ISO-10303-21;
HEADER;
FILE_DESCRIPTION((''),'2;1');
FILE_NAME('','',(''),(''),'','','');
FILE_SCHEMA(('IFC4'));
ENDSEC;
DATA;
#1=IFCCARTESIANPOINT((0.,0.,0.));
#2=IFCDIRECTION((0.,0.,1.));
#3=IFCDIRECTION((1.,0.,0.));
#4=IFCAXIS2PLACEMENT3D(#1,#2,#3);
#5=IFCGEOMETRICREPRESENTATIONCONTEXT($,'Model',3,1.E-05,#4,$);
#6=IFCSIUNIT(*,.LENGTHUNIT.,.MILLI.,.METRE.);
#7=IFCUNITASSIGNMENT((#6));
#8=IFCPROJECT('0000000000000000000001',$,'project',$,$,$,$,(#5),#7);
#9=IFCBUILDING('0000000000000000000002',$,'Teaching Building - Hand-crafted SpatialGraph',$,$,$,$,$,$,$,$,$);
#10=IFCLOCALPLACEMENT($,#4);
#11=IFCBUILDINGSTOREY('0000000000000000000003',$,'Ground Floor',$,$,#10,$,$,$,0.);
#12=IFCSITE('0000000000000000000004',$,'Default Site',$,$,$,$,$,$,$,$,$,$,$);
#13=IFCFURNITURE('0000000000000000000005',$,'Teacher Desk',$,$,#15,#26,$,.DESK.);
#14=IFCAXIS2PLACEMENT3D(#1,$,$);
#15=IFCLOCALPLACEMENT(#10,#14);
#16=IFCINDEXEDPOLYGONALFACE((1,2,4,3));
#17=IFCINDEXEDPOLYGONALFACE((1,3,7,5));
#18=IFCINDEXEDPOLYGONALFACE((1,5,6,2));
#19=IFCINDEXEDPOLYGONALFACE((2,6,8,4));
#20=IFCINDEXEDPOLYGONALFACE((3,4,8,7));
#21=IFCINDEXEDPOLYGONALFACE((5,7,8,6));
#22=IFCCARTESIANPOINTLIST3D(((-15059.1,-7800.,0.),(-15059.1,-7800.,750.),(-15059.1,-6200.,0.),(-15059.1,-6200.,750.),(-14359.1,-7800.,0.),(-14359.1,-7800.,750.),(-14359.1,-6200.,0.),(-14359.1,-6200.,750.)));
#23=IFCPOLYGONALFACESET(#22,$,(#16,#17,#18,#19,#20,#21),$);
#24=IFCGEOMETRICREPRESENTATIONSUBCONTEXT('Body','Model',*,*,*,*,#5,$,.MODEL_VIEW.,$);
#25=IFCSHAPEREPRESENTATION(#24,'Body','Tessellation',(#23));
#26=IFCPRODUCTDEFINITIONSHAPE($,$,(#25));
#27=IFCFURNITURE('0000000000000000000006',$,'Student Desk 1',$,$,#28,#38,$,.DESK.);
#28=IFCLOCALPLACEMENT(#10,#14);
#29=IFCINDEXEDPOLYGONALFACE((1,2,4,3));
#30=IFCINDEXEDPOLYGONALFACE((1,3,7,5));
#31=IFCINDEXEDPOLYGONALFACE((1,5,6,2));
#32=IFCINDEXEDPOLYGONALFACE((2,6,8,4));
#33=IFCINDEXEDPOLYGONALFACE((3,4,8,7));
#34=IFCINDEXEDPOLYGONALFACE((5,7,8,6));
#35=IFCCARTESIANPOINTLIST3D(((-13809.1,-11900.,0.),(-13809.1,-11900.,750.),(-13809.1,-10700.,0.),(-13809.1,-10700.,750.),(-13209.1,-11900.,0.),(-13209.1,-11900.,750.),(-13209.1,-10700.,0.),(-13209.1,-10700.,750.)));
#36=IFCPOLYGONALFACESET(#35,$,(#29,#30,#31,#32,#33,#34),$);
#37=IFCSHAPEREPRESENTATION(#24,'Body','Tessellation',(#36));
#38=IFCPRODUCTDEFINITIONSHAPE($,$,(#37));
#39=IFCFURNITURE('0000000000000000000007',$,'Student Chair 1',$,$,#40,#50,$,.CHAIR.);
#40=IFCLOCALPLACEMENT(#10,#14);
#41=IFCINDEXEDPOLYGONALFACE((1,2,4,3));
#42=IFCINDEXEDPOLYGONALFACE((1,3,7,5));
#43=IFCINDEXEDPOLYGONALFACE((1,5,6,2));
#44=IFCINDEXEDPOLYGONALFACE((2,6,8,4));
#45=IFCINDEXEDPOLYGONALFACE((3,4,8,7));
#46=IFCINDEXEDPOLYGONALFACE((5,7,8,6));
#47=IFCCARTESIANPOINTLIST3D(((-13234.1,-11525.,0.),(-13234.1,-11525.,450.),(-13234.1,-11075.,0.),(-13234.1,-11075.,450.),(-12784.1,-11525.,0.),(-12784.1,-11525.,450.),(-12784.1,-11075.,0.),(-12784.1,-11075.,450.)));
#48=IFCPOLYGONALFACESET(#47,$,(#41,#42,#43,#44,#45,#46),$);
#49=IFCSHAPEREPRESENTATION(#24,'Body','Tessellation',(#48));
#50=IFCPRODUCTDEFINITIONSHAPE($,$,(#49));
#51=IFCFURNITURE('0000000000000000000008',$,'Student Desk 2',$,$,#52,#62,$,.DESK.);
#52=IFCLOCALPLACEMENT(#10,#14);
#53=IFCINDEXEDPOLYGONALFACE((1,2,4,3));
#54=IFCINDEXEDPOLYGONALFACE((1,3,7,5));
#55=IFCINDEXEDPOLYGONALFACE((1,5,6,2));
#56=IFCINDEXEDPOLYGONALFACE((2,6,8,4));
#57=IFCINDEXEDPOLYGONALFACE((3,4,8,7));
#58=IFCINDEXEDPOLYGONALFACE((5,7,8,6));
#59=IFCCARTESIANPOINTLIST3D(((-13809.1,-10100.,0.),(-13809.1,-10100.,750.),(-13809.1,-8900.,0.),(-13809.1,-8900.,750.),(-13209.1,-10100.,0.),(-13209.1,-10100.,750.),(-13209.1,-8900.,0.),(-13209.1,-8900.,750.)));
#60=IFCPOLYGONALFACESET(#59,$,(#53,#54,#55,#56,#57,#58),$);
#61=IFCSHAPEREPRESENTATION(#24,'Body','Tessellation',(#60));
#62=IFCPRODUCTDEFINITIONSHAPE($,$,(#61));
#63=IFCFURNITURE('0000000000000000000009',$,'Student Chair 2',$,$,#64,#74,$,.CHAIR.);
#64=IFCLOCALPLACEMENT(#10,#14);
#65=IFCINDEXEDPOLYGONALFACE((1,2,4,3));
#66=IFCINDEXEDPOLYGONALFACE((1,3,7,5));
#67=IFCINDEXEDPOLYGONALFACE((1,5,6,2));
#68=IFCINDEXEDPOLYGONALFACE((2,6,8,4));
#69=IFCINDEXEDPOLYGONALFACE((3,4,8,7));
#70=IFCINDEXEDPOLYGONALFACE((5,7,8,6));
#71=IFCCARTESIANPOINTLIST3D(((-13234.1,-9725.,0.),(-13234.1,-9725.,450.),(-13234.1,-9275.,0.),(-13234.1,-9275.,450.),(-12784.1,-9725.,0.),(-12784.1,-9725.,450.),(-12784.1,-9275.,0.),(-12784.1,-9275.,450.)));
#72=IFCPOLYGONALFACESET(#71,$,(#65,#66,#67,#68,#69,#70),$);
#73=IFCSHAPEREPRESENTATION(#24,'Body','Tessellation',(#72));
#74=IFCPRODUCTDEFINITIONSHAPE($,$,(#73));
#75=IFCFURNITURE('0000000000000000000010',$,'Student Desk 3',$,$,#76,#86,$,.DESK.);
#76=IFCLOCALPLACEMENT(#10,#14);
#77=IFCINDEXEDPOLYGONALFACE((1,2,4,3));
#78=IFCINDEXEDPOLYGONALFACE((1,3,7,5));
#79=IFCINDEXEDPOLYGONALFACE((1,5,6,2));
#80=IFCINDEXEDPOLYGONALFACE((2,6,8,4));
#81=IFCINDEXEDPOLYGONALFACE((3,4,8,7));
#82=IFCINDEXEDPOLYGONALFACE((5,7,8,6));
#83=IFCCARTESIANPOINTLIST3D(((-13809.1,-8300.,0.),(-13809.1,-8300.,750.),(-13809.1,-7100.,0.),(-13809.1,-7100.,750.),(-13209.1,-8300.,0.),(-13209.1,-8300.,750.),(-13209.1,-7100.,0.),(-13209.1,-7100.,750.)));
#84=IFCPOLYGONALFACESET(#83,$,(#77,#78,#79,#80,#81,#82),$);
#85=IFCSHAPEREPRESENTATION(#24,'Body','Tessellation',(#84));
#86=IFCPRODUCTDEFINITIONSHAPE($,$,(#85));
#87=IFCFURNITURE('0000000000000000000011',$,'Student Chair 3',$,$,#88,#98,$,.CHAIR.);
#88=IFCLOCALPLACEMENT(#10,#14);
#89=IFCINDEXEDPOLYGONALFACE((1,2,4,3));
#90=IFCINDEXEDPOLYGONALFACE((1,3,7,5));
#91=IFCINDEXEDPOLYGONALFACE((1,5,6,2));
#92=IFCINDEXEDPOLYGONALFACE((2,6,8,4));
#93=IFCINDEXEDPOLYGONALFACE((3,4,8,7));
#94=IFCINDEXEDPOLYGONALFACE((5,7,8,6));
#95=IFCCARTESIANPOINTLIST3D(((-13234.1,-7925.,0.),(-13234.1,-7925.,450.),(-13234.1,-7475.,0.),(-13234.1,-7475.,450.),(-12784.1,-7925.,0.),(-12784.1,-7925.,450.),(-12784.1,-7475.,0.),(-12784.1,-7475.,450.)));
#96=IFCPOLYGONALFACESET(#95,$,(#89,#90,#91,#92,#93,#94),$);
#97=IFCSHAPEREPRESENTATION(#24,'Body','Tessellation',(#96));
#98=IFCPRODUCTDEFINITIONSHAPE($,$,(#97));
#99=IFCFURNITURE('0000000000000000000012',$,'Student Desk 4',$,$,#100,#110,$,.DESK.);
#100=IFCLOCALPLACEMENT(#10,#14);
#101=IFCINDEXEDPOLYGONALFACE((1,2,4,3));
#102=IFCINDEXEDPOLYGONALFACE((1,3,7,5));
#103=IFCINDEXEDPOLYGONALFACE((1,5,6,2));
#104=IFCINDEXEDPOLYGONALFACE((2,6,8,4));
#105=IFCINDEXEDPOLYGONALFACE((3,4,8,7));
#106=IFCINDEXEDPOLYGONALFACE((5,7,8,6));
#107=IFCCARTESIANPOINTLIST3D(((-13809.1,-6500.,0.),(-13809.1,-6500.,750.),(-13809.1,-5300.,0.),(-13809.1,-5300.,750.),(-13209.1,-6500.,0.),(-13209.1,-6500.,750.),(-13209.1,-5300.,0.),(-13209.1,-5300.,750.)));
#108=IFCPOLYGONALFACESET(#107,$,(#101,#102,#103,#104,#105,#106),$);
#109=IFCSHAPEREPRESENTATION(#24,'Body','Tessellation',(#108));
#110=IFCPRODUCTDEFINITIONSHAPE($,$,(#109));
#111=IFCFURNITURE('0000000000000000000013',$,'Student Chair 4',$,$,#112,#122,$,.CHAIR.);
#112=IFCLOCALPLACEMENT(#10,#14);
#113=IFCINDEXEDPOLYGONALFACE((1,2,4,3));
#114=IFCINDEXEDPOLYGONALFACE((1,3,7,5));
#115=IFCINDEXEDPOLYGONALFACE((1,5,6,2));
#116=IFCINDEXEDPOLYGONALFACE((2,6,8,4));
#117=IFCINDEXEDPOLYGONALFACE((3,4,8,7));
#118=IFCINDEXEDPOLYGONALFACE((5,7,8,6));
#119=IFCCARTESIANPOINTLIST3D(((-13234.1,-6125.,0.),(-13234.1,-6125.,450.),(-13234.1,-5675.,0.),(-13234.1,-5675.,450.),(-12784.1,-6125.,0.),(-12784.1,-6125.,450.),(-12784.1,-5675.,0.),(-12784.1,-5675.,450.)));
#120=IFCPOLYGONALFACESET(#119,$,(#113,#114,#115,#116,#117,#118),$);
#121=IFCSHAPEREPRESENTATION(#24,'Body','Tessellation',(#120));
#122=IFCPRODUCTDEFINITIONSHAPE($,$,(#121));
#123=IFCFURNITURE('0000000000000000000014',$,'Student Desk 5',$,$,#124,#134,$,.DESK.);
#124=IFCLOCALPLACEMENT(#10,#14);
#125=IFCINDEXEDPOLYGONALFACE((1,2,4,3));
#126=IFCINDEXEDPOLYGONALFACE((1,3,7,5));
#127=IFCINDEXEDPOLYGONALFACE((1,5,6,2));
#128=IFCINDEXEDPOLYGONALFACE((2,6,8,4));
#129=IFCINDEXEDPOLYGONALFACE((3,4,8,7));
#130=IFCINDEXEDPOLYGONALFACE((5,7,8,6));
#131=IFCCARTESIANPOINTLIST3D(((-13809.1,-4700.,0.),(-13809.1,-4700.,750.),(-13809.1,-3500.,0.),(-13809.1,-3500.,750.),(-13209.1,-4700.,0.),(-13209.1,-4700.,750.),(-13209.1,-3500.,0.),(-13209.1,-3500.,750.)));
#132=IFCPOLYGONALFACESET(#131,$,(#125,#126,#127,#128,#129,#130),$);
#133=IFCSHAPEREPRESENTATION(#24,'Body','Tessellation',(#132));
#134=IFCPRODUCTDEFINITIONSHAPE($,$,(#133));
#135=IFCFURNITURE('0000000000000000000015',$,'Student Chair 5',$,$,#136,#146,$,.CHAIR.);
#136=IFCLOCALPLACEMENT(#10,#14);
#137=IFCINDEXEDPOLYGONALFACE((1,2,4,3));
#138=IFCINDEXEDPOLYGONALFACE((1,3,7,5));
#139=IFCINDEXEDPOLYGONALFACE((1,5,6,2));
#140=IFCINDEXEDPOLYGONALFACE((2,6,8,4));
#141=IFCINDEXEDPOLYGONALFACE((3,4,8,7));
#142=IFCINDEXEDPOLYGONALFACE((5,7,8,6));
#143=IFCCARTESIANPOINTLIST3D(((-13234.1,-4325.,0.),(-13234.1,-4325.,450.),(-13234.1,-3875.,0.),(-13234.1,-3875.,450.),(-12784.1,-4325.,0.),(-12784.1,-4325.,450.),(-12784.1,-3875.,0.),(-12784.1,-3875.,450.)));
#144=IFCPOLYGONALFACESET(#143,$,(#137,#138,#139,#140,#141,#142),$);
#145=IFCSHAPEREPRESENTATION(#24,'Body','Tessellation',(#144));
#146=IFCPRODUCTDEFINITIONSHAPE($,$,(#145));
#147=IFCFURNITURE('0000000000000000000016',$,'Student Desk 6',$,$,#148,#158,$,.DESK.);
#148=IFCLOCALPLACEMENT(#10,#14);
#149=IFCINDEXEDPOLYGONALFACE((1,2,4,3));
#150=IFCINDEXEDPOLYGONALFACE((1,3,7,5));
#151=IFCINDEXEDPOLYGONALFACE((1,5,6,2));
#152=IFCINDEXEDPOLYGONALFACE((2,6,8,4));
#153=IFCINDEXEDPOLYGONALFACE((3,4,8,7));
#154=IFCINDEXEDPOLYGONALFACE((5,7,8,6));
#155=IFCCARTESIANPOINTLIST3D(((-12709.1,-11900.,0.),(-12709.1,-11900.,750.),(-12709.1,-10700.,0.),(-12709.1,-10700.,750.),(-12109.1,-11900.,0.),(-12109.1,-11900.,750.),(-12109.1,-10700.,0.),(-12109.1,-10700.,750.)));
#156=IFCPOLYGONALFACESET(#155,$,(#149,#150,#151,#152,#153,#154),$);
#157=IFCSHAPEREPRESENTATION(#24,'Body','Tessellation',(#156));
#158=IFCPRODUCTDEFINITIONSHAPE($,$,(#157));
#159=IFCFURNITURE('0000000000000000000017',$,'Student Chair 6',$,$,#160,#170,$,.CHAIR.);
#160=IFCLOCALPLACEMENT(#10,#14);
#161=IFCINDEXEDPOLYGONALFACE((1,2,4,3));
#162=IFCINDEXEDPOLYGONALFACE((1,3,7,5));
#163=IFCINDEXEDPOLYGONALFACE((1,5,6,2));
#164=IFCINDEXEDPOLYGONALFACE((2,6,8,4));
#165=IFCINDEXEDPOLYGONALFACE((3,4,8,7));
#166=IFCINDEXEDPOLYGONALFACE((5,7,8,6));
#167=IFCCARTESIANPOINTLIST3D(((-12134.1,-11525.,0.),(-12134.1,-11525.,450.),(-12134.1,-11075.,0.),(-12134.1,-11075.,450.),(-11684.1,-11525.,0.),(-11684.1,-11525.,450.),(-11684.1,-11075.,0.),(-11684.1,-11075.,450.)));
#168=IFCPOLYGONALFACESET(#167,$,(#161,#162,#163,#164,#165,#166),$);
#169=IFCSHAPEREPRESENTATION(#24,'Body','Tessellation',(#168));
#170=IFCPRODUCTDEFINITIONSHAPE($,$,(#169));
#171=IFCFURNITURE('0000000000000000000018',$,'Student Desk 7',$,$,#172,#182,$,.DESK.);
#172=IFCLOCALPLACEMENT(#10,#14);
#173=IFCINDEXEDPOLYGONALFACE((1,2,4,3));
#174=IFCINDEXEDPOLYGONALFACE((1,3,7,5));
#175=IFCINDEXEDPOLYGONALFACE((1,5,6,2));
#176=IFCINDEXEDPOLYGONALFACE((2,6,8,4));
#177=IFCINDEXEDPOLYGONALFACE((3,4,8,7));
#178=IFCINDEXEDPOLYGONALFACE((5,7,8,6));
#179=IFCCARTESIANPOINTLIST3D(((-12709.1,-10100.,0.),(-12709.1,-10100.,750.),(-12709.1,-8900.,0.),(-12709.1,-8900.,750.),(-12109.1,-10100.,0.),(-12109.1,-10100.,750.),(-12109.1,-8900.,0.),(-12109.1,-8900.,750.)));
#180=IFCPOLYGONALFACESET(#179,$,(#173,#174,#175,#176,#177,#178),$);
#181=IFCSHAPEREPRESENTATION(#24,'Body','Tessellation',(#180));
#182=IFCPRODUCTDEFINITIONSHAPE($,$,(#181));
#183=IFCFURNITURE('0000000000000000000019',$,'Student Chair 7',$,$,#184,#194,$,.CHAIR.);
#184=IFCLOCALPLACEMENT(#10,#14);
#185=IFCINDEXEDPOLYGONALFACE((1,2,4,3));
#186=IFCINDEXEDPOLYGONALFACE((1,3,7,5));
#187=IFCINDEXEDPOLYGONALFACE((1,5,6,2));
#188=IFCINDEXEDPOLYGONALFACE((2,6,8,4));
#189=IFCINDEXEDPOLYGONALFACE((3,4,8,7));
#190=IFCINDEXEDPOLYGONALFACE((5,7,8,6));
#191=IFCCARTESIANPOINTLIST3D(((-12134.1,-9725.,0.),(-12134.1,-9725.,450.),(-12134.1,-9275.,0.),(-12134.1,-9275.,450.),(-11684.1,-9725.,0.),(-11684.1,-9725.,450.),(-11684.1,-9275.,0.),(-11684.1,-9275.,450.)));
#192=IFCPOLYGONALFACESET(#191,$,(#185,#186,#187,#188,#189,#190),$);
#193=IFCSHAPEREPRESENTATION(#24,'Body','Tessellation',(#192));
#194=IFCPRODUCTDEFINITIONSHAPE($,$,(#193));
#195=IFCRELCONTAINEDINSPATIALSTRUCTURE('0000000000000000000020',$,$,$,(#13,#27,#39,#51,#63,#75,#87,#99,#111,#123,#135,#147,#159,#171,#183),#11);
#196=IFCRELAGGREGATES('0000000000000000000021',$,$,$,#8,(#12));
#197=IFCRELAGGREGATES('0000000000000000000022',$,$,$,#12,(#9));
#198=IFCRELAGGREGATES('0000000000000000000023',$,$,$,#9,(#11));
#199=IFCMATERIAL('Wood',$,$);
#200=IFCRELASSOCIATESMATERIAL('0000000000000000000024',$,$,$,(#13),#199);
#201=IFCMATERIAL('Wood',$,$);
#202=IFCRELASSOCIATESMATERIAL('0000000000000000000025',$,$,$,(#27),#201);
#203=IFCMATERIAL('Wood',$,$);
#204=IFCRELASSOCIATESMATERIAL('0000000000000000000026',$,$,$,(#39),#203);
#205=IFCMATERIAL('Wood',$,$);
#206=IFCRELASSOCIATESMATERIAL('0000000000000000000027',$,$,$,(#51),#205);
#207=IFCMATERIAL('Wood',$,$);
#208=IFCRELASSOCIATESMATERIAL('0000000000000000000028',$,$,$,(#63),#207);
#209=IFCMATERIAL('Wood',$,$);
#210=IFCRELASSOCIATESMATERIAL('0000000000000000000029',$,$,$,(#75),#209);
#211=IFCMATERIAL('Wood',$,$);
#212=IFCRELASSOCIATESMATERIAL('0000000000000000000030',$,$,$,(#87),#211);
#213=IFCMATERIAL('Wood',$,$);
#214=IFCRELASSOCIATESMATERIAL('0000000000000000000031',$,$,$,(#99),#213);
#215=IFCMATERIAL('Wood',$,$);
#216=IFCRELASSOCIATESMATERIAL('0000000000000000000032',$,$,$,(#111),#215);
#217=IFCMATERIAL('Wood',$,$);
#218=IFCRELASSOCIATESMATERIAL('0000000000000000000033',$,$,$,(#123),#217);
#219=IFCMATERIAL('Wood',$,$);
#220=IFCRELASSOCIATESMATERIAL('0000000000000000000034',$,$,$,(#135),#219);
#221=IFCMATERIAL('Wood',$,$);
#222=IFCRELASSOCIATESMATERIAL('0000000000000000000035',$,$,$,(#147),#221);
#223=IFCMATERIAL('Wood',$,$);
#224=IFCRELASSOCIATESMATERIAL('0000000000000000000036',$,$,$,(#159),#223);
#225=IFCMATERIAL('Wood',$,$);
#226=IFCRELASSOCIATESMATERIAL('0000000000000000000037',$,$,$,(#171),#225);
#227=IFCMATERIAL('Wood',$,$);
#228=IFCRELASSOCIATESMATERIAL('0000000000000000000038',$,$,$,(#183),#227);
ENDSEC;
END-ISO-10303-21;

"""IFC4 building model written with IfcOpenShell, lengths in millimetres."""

from ifc_helpers import new_model, si_unit, frame, origin_with_axes, origin_2d, place, context, subcontext, project, spatial, rectangle, extrude, material, element, save


model = new_model("IFC4")

# Units and contexts
model_context = context("Model", 3, precision=1e-05, world=origin_with_axes())
body_context = subcontext(model_context, "Body", "Model", "MODEL_VIEW")
ifc_project = project(units=[si_unit("LENGTHUNIT", "METRE", prefix="MILLI")], contexts=[model_context])

# Site, building, storey
site = spatial("IfcSite", under=ifc_project, Name="Default Site")
building = spatial("IfcBuilding", under=site, Name="Teaching Building - Hand-crafted SpatialGraph")
storey_placement = place(None, origin_with_axes())
storey = spatial("IfcBuildingStorey", under=building, at=storey_placement, Name="Ground Floor", Elevation=0.0)

# Furniture
ifc_material_1 = material(Name="Wood")
furniture_1_placement = place(storey_placement, frame((-14709.1, -7000.0, 0.0), z_axis=(0.0, 0.0, 1.0), x_axis=(0.0, 1.0, 0.0)))
element("IfcFurniture", 1, at=furniture_1_placement, inside=storey, material=ifc_material_1, Name="Teacher Desk", PredefinedType="DESK", context=body_context, shape_type="SweptSolid", body=[
    extrude(rectangle(XDim=1600.0, YDim=700.0, at=origin_2d()), origin_with_axes(), (0.0, 0.0, 1.0), 750.0),
])
ifc_material_2 = material(Name="Wood")
furniture_2_placement = place(storey_placement, frame((-13509.1, -11300.0, 0.0), z_axis=(0.0, 0.0, 1.0), x_axis=(0.0, 1.0, 0.0)))
element("IfcFurniture", 2, at=furniture_2_placement, inside=storey, material=ifc_material_2, Name="Student Desk 1", PredefinedType="DESK", context=body_context, shape_type="SweptSolid", body=[
    extrude(rectangle(XDim=1200.0, YDim=600.0, at=origin_2d()), origin_with_axes(), (0.0, 0.0, 1.0), 750.0),
])
ifc_material_3 = material(Name="Wood")
furniture_3_placement = place(storey_placement, frame((-13009.1, -11300.0, 0.0), z_axis=(0.0, 0.0, 1.0), x_axis=(1.0, 0.0, 0.0)))
element("IfcFurniture", 3, at=furniture_3_placement, inside=storey, material=ifc_material_3, Name="Student Chair 1", PredefinedType="CHAIR", context=body_context, shape_type="SweptSolid", body=[
    extrude(rectangle(XDim=450.0, YDim=450.0, at=origin_2d()), origin_with_axes(), (0.0, 0.0, 1.0), 450.0),
])
ifc_material_4 = material(Name="Wood")
furniture_4_placement = place(storey_placement, frame((-13509.1, -9500.0, 0.0), z_axis=(0.0, 0.0, 1.0), x_axis=(0.0, 1.0, 0.0)))
element("IfcFurniture", 4, at=furniture_4_placement, inside=storey, material=ifc_material_4, Name="Student Desk 2", PredefinedType="DESK", context=body_context, shape_type="SweptSolid", body=[
    extrude(rectangle(XDim=1200.0, YDim=600.0, at=origin_2d()), origin_with_axes(), (0.0, 0.0, 1.0), 750.0),
])
ifc_material_5 = material(Name="Wood")
furniture_5_placement = place(storey_placement, frame((-13009.1, -9500.0, 0.0), z_axis=(0.0, 0.0, 1.0), x_axis=(1.0, 0.0, 0.0)))
element("IfcFurniture", 5, at=furniture_5_placement, inside=storey, material=ifc_material_5, Name="Student Chair 2", PredefinedType="CHAIR", context=body_context, shape_type="SweptSolid", body=[
    extrude(rectangle(XDim=450.0, YDim=450.0, at=origin_2d()), origin_with_axes(), (0.0, 0.0, 1.0), 450.0),
])
ifc_material_6 = material(Name="Wood")
furniture_6_placement = place(storey_placement, frame((-13509.1, -7700.0, 0.0), z_axis=(0.0, 0.0, 1.0), x_axis=(0.0, 1.0, 0.0)))
element("IfcFurniture", 6, at=furniture_6_placement, inside=storey, material=ifc_material_6, Name="Student Desk 3", PredefinedType="DESK", context=body_context, shape_type="SweptSolid", body=[
    extrude(rectangle(XDim=1200.0, YDim=600.0, at=origin_2d()), origin_with_axes(), (0.0, 0.0, 1.0), 750.0),
])
ifc_material_7 = material(Name="Wood")
furniture_7_placement = place(storey_placement, frame((-13009.1, -7700.0, 0.0), z_axis=(0.0, 0.0, 1.0), x_axis=(1.0, 0.0, 0.0)))
element("IfcFurniture", 7, at=furniture_7_placement, inside=storey, material=ifc_material_7, Name="Student Chair 3", PredefinedType="CHAIR", context=body_context, shape_type="SweptSolid", body=[
    extrude(rectangle(XDim=450.0, YDim=450.0, at=origin_2d()), origin_with_axes(), (0.0, 0.0, 1.0), 450.0),
])
ifc_material_8 = material(Name="Wood")
furniture_8_placement = place(storey_placement, frame((-13509.1, -5900.0, 0.0), z_axis=(0.0, 0.0, 1.0), x_axis=(0.0, 1.0, 0.0)))
element("IfcFurniture", 8, at=furniture_8_placement, inside=storey, material=ifc_material_8, Name="Student Desk 4", PredefinedType="DESK", context=body_context, shape_type="SweptSolid", body=[
    extrude(rectangle(XDim=1200.0, YDim=600.0, at=origin_2d()), origin_with_axes(), (0.0, 0.0, 1.0), 750.0),
])
ifc_material_9 = material(Name="Wood")
furniture_9_placement = place(storey_placement, frame((-13009.1, -5900.0, 0.0), z_axis=(0.0, 0.0, 1.0), x_axis=(1.0, 0.0, 0.0)))
element("IfcFurniture", 9, at=furniture_9_placement, inside=storey, material=ifc_material_9, Name="Student Chair 4", PredefinedType="CHAIR", context=body_context, shape_type="SweptSolid", body=[
    extrude(rectangle(XDim=450.0, YDim=450.0, at=origin_2d()), origin_with_axes(), (0.0, 0.0, 1.0), 450.0),
])
ifc_material_10 = material(Name="Wood")
furniture_10_placement = place(storey_placement, frame((-13509.1, -4100.0, 0.0), z_axis=(0.0, 0.0, 1.0), x_axis=(0.0, 1.0, 0.0)))
element("IfcFurniture", 10, at=furniture_10_placement, inside=storey, material=ifc_material_10, Name="Student Desk 5", PredefinedType="DESK", context=body_context, shape_type="SweptSolid", body=[
    extrude(rectangle(XDim=1200.0, YDim=600.0, at=origin_2d()), origin_with_axes(), (0.0, 0.0, 1.0), 750.0),
])
ifc_material_11 = material(Name="Wood")
furniture_11_placement = place(storey_placement, frame((-13009.1, -4100.0, 0.0), z_axis=(0.0, 0.0, 1.0), x_axis=(1.0, 0.0, 0.0)))
element("IfcFurniture", 11, at=furniture_11_placement, inside=storey, material=ifc_material_11, Name="Student Chair 5", PredefinedType="CHAIR", context=body_context, shape_type="SweptSolid", body=[
    extrude(rectangle(XDim=450.0, YDim=450.0, at=origin_2d()), origin_with_axes(), (0.0, 0.0, 1.0), 450.0),
])
ifc_material_12 = material(Name="Wood")
furniture_12_placement = place(storey_placement, frame((-12409.1, -11300.0, 0.0), z_axis=(0.0, 0.0, 1.0), x_axis=(0.0, 1.0, 0.0)))
element("IfcFurniture", 12, at=furniture_12_placement, inside=storey, material=ifc_material_12, Name="Student Desk 6", PredefinedType="DESK", context=body_context, shape_type="SweptSolid", body=[
    extrude(rectangle(XDim=1200.0, YDim=600.0, at=origin_2d()), origin_with_axes(), (0.0, 0.0, 1.0), 750.0),
])
ifc_material_13 = material(Name="Wood")
furniture_13_placement = place(storey_placement, frame((-11909.1, -11300.0, 0.0), z_axis=(0.0, 0.0, 1.0), x_axis=(1.0, 0.0, 0.0)))
element("IfcFurniture", 13, at=furniture_13_placement, inside=storey, material=ifc_material_13, Name="Student Chair 6", PredefinedType="CHAIR", context=body_context, shape_type="SweptSolid", body=[
    extrude(rectangle(XDim=450.0, YDim=450.0, at=origin_2d()), origin_with_axes(), (0.0, 0.0, 1.0), 450.0),
])
ifc_material_14 = material(Name="Wood")
furniture_14_placement = place(storey_placement, frame((-12409.1, -9500.0, 0.0), z_axis=(0.0, 0.0, 1.0), x_axis=(0.0, 1.0, 0.0)))
element("IfcFurniture", 14, at=furniture_14_placement, inside=storey, material=ifc_material_14, Name="Student Desk 7", PredefinedType="DESK", context=body_context, shape_type="SweptSolid", body=[
    extrude(rectangle(XDim=1200.0, YDim=600.0, at=origin_2d()), origin_with_axes(), (0.0, 0.0, 1.0), 750.0),
])
ifc_material_15 = material(Name="Wood")
furniture_15_placement = place(storey_placement, frame((-11909.1, -9500.0, 0.0), z_axis=(0.0, 0.0, 1.0), x_axis=(1.0, 0.0, 0.0)))
element("IfcFurniture", 15, at=furniture_15_placement, inside=storey, material=ifc_material_15, Name="Student Chair 7", PredefinedType="CHAIR", context=body_context, shape_type="SweptSolid", body=[
    extrude(rectangle(XDim=450.0, YDim=450.0, at=origin_2d()), origin_with_axes(), (0.0, 0.0, 1.0), 450.0),
])

save(model, "model.ifc")
